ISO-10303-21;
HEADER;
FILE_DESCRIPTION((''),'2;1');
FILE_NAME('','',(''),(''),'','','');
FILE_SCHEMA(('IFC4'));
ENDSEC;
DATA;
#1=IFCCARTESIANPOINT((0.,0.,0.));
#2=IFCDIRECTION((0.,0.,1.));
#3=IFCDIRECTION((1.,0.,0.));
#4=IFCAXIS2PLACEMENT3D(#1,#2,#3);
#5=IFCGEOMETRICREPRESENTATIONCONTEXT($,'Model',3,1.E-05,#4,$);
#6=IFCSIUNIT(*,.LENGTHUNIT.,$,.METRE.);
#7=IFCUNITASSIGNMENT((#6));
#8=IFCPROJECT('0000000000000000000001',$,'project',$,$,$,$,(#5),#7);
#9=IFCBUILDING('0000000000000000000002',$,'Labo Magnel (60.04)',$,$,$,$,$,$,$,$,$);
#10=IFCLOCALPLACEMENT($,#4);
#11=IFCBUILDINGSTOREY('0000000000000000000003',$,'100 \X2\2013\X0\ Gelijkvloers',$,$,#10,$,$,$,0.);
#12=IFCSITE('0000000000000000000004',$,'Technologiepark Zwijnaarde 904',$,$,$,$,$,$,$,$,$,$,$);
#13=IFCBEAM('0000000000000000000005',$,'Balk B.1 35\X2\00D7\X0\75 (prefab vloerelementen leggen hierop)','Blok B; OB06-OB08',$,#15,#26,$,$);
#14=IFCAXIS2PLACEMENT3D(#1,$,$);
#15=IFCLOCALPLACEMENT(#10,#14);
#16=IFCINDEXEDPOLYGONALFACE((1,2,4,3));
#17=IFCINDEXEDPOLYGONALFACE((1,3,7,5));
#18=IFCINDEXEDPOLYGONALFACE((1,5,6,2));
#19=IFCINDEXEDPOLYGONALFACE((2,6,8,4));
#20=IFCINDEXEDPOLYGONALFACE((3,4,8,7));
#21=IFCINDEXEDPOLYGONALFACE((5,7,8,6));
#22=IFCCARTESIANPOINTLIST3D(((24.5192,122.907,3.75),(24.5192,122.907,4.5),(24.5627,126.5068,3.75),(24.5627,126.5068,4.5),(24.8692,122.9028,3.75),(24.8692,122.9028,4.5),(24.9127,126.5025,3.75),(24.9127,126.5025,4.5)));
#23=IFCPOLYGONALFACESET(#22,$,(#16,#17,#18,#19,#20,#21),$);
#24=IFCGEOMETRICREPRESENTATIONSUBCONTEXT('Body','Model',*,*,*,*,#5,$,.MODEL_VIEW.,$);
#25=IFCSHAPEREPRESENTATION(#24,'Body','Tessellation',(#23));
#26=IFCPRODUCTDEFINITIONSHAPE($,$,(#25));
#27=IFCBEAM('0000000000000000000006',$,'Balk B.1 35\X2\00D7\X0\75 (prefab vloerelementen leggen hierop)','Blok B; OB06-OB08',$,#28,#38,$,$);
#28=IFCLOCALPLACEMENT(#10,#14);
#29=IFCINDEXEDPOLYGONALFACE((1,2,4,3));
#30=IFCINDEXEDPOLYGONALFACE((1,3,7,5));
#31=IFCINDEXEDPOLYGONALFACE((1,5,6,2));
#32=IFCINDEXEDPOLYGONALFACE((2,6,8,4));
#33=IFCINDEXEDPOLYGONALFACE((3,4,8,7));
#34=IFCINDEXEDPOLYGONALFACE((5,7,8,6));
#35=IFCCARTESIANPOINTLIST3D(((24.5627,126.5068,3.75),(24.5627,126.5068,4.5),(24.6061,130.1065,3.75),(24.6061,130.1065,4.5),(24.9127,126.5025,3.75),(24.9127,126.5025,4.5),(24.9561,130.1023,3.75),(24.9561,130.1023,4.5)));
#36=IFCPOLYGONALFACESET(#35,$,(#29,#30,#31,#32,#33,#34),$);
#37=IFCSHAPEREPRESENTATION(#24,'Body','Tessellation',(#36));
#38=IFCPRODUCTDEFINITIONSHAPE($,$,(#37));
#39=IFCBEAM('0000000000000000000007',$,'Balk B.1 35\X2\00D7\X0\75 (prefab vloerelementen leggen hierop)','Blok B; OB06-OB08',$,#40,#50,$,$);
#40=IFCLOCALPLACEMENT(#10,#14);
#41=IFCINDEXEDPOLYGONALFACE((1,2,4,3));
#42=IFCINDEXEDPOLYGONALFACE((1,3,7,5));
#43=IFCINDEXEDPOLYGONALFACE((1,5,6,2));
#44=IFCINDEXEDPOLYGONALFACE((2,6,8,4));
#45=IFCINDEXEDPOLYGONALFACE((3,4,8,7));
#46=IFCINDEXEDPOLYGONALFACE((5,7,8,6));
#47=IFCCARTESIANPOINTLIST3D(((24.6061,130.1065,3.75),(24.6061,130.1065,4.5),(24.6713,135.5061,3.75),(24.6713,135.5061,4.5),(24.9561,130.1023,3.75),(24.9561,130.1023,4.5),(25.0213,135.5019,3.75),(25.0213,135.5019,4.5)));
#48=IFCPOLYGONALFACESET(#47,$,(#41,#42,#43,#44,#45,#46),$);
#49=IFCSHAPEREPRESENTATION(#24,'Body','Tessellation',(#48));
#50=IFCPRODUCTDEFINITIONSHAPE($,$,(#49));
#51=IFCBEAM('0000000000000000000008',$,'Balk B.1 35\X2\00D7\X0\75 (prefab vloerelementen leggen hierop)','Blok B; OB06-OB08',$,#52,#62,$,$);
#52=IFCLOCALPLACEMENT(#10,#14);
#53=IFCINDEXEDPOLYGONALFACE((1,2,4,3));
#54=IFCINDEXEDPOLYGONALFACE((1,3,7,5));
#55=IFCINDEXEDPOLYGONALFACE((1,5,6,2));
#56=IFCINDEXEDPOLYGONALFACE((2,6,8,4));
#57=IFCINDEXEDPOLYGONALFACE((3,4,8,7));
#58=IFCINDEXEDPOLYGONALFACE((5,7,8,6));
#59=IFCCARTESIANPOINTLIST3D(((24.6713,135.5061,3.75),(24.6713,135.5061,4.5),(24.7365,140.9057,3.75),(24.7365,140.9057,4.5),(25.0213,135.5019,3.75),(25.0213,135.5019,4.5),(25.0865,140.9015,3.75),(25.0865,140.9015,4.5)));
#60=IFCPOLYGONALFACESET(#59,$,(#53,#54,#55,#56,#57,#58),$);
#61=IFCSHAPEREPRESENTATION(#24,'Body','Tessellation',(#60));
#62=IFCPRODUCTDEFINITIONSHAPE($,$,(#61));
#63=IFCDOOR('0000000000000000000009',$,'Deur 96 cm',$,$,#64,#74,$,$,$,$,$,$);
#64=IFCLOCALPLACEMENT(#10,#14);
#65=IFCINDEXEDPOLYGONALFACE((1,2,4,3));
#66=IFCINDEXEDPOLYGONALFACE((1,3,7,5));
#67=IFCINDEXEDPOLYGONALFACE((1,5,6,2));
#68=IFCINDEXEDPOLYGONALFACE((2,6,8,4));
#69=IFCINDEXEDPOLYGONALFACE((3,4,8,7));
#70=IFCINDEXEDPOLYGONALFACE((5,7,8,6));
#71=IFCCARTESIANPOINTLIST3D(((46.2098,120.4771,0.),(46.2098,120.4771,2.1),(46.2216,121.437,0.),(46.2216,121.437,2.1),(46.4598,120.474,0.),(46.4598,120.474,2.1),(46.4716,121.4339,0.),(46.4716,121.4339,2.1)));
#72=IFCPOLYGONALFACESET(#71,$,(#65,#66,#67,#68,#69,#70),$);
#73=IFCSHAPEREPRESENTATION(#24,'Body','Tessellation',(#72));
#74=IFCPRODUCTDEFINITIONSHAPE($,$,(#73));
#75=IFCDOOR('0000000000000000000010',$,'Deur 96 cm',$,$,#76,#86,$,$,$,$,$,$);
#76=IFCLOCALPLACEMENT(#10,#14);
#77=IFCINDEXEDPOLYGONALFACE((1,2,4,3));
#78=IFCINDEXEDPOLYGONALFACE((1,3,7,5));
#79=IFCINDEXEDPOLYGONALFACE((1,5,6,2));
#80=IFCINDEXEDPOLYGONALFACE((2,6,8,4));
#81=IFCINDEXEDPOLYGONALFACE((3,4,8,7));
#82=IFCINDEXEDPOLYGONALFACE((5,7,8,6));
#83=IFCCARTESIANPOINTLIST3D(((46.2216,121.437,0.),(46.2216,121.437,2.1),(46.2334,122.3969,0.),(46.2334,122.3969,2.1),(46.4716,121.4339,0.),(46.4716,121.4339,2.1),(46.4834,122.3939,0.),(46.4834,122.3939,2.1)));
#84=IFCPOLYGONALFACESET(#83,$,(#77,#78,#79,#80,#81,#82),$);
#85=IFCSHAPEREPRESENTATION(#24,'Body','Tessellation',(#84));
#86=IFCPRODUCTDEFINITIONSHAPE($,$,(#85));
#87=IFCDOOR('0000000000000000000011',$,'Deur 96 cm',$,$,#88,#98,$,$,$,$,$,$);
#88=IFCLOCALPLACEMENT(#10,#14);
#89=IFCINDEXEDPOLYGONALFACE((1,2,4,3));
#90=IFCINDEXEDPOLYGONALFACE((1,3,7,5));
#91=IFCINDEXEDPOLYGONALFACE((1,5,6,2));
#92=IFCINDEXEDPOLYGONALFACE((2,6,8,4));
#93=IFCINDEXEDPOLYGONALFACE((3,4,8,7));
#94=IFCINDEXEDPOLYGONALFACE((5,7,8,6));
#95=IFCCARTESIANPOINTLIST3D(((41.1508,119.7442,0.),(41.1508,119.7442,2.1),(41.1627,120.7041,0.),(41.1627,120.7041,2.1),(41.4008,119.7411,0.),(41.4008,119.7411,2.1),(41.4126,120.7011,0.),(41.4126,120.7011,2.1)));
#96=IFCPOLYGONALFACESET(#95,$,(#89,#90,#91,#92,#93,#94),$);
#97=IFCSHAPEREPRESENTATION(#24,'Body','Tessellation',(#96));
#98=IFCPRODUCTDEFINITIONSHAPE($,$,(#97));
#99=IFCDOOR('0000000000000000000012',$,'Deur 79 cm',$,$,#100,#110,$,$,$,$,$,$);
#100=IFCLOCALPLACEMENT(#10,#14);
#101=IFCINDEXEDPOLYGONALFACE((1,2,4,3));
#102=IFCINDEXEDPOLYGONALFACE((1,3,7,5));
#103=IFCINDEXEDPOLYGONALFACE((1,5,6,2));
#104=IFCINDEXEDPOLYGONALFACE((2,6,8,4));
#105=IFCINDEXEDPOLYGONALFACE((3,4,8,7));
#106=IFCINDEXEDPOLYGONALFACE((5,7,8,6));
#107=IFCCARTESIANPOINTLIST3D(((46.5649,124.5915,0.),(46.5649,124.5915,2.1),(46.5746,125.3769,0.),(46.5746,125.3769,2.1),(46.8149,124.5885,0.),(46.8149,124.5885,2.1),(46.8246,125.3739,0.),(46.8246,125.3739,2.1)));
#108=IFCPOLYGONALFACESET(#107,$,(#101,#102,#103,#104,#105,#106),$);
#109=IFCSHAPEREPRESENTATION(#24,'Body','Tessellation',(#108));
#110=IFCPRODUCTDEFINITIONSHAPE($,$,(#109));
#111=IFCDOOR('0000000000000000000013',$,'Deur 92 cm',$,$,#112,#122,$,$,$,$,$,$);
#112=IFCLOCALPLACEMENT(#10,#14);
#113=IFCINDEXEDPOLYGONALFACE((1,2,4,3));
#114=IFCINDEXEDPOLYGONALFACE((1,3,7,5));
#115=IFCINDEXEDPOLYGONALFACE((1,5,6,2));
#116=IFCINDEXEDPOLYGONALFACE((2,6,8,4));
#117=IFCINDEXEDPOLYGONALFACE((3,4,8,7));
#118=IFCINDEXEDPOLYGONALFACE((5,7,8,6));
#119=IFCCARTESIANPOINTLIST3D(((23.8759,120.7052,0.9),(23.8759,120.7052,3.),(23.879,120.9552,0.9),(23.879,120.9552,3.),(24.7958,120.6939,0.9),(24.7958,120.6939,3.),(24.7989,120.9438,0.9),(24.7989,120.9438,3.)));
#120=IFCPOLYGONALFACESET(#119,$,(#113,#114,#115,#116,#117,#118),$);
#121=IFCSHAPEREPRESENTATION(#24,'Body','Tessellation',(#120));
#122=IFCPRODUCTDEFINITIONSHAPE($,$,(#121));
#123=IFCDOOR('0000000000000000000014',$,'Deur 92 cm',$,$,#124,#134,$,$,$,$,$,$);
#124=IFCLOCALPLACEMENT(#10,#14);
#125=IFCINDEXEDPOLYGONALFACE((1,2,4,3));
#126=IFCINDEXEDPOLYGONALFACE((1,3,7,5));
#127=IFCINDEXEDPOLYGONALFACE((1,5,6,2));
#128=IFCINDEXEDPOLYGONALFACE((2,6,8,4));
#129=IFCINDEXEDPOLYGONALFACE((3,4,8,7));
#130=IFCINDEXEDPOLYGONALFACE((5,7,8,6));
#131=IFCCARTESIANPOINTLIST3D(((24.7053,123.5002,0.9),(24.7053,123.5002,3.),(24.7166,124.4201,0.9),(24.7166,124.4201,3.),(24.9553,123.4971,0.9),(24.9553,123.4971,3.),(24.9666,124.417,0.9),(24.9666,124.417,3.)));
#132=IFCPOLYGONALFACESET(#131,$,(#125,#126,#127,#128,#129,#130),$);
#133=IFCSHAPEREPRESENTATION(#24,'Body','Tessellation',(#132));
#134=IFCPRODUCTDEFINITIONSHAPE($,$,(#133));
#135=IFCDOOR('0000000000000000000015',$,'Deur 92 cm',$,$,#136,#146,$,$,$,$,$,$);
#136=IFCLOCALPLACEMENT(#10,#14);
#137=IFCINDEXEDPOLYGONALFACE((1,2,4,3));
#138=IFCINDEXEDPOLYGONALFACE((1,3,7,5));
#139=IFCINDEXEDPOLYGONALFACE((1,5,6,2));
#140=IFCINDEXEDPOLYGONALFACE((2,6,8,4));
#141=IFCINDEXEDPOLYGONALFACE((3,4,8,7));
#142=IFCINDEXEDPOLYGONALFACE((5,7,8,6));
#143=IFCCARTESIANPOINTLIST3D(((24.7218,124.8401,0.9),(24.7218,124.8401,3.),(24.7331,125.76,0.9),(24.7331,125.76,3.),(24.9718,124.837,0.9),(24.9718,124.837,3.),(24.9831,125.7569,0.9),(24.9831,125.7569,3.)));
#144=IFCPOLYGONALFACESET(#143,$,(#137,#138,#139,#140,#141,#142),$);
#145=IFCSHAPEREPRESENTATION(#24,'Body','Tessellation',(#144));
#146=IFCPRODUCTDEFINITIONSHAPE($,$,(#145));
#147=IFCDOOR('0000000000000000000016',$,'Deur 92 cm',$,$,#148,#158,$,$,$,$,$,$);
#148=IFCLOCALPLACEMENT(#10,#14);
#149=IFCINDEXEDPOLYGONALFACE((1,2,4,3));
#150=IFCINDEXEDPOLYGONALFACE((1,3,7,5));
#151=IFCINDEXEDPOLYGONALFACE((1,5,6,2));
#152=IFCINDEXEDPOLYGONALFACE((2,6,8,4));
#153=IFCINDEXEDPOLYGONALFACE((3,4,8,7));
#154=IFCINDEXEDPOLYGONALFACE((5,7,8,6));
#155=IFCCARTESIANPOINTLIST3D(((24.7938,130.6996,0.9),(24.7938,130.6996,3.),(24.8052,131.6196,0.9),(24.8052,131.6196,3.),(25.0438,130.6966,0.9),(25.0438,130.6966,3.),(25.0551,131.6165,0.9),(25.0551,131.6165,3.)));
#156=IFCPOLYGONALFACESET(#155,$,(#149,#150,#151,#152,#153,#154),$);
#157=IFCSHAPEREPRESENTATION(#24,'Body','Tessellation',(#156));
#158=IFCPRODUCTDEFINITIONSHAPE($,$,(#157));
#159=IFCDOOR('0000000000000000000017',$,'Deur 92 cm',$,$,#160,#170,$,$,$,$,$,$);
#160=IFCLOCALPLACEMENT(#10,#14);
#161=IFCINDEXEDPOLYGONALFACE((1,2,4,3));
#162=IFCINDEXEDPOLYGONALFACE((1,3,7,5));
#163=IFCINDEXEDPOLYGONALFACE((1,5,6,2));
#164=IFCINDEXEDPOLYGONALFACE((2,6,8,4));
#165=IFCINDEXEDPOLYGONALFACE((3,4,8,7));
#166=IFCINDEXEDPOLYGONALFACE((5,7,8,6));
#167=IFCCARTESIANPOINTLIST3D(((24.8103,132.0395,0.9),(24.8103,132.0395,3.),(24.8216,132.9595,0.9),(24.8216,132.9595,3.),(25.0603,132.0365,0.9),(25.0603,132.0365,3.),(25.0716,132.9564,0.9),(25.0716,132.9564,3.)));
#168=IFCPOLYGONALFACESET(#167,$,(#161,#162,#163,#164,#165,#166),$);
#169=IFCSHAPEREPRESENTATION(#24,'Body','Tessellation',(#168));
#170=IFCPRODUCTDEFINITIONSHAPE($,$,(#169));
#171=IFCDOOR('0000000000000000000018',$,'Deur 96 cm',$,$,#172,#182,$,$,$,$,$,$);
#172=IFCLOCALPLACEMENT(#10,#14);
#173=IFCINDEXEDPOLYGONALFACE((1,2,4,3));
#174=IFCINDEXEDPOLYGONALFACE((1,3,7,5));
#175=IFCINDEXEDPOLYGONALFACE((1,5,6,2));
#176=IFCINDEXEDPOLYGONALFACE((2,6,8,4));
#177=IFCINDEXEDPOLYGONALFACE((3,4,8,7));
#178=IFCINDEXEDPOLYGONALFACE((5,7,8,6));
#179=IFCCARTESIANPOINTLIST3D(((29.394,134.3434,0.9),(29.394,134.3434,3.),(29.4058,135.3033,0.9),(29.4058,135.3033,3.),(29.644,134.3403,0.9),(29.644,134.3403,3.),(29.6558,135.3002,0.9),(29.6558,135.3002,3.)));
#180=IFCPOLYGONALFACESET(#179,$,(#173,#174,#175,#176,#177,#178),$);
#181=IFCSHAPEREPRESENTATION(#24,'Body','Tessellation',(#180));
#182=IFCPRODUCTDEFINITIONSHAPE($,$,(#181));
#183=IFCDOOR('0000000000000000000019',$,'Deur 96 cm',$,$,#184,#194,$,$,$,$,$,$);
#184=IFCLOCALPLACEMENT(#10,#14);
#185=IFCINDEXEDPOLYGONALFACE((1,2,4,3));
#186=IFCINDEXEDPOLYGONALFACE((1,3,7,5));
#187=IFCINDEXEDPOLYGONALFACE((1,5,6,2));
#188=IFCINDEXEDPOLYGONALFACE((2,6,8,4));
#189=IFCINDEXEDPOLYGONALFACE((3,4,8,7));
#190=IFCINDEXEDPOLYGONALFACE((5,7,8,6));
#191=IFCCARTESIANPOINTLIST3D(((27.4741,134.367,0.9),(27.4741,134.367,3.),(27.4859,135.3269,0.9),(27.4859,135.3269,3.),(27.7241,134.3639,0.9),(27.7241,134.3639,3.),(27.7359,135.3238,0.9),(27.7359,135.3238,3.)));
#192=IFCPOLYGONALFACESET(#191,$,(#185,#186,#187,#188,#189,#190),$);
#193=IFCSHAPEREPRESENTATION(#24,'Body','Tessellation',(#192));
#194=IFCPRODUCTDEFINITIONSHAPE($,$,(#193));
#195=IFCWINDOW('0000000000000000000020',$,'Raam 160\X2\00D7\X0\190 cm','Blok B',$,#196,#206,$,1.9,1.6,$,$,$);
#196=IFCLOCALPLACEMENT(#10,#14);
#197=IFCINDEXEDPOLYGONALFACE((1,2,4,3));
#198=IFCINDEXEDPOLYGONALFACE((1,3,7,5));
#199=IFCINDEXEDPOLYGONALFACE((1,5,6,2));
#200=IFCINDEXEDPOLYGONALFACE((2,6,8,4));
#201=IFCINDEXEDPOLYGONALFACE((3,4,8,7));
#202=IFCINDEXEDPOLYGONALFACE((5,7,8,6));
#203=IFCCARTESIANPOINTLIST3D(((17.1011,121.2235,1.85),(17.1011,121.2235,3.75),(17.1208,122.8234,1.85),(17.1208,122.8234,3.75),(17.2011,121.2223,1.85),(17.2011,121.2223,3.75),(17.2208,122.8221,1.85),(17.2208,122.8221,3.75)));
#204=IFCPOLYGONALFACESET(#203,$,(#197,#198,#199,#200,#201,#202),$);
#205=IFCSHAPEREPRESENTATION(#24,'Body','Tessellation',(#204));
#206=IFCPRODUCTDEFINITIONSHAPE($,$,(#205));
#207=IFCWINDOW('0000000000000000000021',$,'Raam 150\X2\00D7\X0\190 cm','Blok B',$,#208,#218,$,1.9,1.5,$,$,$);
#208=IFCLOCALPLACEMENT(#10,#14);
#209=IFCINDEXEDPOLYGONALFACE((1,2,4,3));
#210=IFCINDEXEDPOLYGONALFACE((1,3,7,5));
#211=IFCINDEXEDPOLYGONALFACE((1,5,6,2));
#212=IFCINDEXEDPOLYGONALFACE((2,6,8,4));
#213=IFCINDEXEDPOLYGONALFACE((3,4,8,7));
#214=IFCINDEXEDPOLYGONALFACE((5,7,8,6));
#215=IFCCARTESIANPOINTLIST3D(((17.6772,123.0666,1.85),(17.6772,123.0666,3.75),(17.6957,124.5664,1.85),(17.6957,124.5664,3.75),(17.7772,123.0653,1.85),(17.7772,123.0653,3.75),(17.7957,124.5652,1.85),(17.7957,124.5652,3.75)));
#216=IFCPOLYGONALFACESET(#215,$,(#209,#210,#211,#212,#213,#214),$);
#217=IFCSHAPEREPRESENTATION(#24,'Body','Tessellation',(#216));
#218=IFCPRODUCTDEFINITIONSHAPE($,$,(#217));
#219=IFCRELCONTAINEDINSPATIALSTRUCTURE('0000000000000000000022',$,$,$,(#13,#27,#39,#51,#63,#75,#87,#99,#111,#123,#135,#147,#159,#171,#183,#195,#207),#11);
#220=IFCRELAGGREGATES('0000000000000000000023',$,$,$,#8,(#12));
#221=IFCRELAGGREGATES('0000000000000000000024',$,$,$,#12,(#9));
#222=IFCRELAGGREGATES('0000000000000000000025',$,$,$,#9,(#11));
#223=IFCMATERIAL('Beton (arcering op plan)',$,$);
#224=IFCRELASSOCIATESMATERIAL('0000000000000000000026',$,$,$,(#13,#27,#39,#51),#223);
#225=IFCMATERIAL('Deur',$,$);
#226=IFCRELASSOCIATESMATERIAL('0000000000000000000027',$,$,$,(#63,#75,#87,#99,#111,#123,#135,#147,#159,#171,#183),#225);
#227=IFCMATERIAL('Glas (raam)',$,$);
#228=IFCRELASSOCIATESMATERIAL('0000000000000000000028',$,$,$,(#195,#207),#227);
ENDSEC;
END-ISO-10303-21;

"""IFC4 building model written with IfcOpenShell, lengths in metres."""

from ifc_helpers import new_model, si_unit, frame, origin, origin_with_axes, place, context, subcontext, project, spatial, polyline, outline, extrude, material, element, save


model = new_model("IFC4")

# Units and contexts
model_context = context("Model", 3, precision=1e-05, world=origin_with_axes())
body_context = subcontext(model_context, "Body", "Model", "MODEL_VIEW")
ifc_project = project(units=[si_unit("LENGTHUNIT", "METRE")], contexts=[model_context])

# Site, building, storey
site = spatial("IfcSite", under=ifc_project, Name="Technologiepark Zwijnaarde 904")
building = spatial("IfcBuilding", under=site, Name="Labo Magnel (60.04)")
storey_placement = place(None, origin_with_axes())
storey = spatial("IfcBuildingStorey", under=building, at=storey_placement, Name="100 – Gelijkvloers", Elevation=0.0)

# Beams
ifc_material_1 = material(Name="Beton (arcering op plan)")
beam_1_placement = place(storey_placement, frame((24.6942, 122.9049, 3.75), z_axis=(0.0, 0.0, 1.0), x_axis=(0.01207, 0.999927, 0.0)))
element("IfcBeam", 1, at=beam_1_placement, inside=storey, material=ifc_material_1, Name="Balk B.1 35×75 (prefab vloerelementen leggen hierop)", Description="Blok B; OB06-OB08", context=body_context, shape_type="SweptSolid", body=[
    extrude(outline(polyline([(0.0, -0.175), (3.6, -0.175), (3.6, 0.175), (0.0, 0.175), (0.0, -0.175)])), origin(), (0.0, 0.0, 1.0), 0.75),
])
beam_2_placement = place(storey_placement, frame((24.7377, 126.5046, 3.75), z_axis=(0.0, 0.0, 1.0), x_axis=(0.01207, 0.999927, 0.0)))
element("IfcBeam", 2, at=beam_2_placement, inside=storey, material=ifc_material_1, Name="Balk B.1 35×75 (prefab vloerelementen leggen hierop)", Description="Blok B; OB06-OB08", context=body_context, shape_type="SweptSolid", body=[
    extrude(outline(polyline([(0.0, -0.175), (3.6, -0.175), (3.6, 0.175), (0.0, 0.175), (0.0, -0.175)])), origin(), (0.0, 0.0, 1.0), 0.75),
])
beam_3_placement = place(storey_placement, frame((24.7811, 130.1044, 3.75), z_axis=(0.0, 0.0, 1.0), x_axis=(0.01207, 0.999927, 0.0)))
element("IfcBeam", 3, at=beam_3_placement, inside=storey, material=ifc_material_1, Name="Balk B.1 35×75 (prefab vloerelementen leggen hierop)", Description="Blok B; OB06-OB08", context=body_context, shape_type="SweptSolid", body=[
    extrude(outline(polyline([(0.0, -0.175), (5.4, -0.175), (5.4, 0.175), (0.0, 0.175), (0.0, -0.175)])), origin(), (0.0, 0.0, 1.0), 0.75),
])
beam_4_placement = place(storey_placement, frame((24.8463, 135.504, 3.75), z_axis=(0.0, 0.0, 1.0), x_axis=(0.01207, 0.999927, 0.0)))
element("IfcBeam", 4, at=beam_4_placement, inside=storey, material=ifc_material_1, Name="Balk B.1 35×75 (prefab vloerelementen leggen hierop)", Description="Blok B; OB06-OB08", context=body_context, shape_type="SweptSolid", body=[
    extrude(outline(polyline([(0.0, -0.175), (5.4, -0.175), (5.4, 0.175), (0.0, 0.175), (0.0, -0.175)])), origin(), (0.0, 0.0, 1.0), 0.75),
])

# Doors
ifc_material_2 = material(Name="Deur")
for number, where, z_axis, x_axis, name in (
    (5, (46.3348, 120.4755, 0.0), (0.0, 0.0, 1.0), (0.012293, 0.999924, 0.0), "Deur 96 cm"),
    (6, (46.3584, 122.3954, 0.0), (0.0, 0.0, 1.0), (-0.012293, -0.999924, 0.0), "Deur 96 cm"),
):
    element("IfcDoor", number, at=place(storey_placement, frame(where, z_axis=z_axis, x_axis=x_axis)), inside=storey, material=ifc_material_2, Name=name, context=body_context, shape_type="SweptSolid", body=[
        extrude(outline(polyline([(0.0, -0.125), (0.96, -0.125), (0.96, 0.125), (0.0, 0.125), (0.0, -0.125)])), origin(), (0.0, 0.0, 1.0), 2.1),
    ])
door_1_placement = place(storey_placement, frame((41.2758, 119.7427, 0.0), z_axis=(0.0, 0.0, 1.0), x_axis=(0.012293, 0.999924, 0.0)))
element("IfcDoor", 7, at=door_1_placement, inside=storey, material=ifc_material_2, Name="Deur 96 cm", context=body_context, shape_type="SweptSolid", body=[
    extrude(outline(polyline([(0.0, -0.125), (0.96, -0.125), (0.96, 0.125), (0.0, 0.125), (0.0, -0.125)])), origin(), (0.0, 0.0, 1.0), 2.1),
])
door_2_placement = place(storey_placement, frame((46.6899, 124.59, 0.0), z_axis=(0.0, 0.0, 1.0), x_axis=(0.012293, 0.999924, 0.0)))
element("IfcDoor", 8, at=door_2_placement, inside=storey, material=ifc_material_2, Name="Deur 79 cm", context=body_context, shape_type="SweptSolid", body=[
    extrude(outline(polyline([(0.0, -0.125), (0.7855, -0.125), (0.7855, 0.125), (0.0, 0.125), (0.0, -0.125)])), origin(), (0.0, 0.0, 1.0), 2.1),
])
for number, where, z_axis, x_axis, name in (
    (9, (24.7974, 120.8189, 0.9), (0.0, 0.0, 1.0), (-0.999924, 0.012293, 0.0), "Deur 92 cm"),
    (10, (24.8416, 124.4186, 0.9), (0.0, 0.0, 1.0), (-0.012293, -0.999924, 0.0), "Deur 92 cm"),
    (11, (24.8468, 124.8386, 0.9), (0.0, 0.0, 1.0), (0.012293, 0.999924, 0.0), "Deur 92 cm"),
    (12, (24.9301, 131.618, 0.9), (0.0, 0.0, 1.0), (-0.012293, -0.999924, 0.0), "Deur 92 cm"),
    (13, (24.9353, 132.038, 0.9), (0.0, 0.0, 1.0), (0.012293, 0.999924, 0.0), "Deur 92 cm"),
):
    element("IfcDoor", number, at=place(storey_placement, frame(where, z_axis=z_axis, x_axis=x_axis)), inside=storey, material=ifc_material_2, Name=name, context=body_context, shape_type="SweptSolid", body=[
        extrude(outline(polyline([(0.0, -0.125), (0.92, -0.125), (0.92, 0.125), (0.0, 0.125), (0.0, -0.125)])), origin(), (0.0, 0.0, 1.0), 2.1),
    ])
for number, where, z_axis, x_axis, name in (
    (14, (29.5308, 135.3018, 0.9), (0.0, 0.0, 1.0), (-0.012293, -0.999924, 0.0), "Deur 96 cm"),
    (15, (27.6109, 135.3254, 0.9), (0.0, 0.0, 1.0), (-0.012293, -0.999924, 0.0), "Deur 96 cm"),
):
    element("IfcDoor", number, at=place(storey_placement, frame(where, z_axis=z_axis, x_axis=x_axis)), inside=storey, material=ifc_material_2, Name=name, context=body_context, shape_type="SweptSolid", body=[
        extrude(outline(polyline([(0.0, -0.125), (0.96, -0.125), (0.96, 0.125), (0.0, 0.125), (0.0, -0.125)])), origin(), (0.0, 0.0, 1.0), 2.1),
    ])

# Windows
ifc_material_3 = material(Name="Glas (raam)")
window_1_placement = place(storey_placement, frame((17.1511, 121.2229, 1.85), z_axis=(0.0, 0.0, 1.0), x_axis=(0.012293, 0.999924, 0.0)))
element("IfcWindow", 16, at=window_1_placement, inside=storey, material=ifc_material_3, Name="Raam 160×190 cm", Description="Blok B", OverallHeight=1.9, OverallWidth=1.6, context=body_context, shape_type="SweptSolid", body=[
    extrude(outline(polyline([(0.0, -0.05), (1.6, -0.05), (1.6, 0.05), (0.0, 0.05), (0.0, -0.05)])), origin(), (0.0, 0.0, 1.0), 1.9),
])
window_2_placement = place(storey_placement, frame((17.7457, 124.5658, 1.85), z_axis=(0.0, 0.0, 1.0), x_axis=(-0.012293, -0.999924, 0.0)))
element("IfcWindow", 17, at=window_2_placement, inside=storey, material=ifc_material_3, Name="Raam 150×190 cm", Description="Blok B", OverallHeight=1.9, OverallWidth=1.5, context=body_context, shape_type="SweptSolid", body=[
    extrude(outline(polyline([(0.0, -0.05), (1.5, -0.05), (1.5, 0.05), (0.0, 0.05), (0.0, -0.05)])), origin(), (0.0, 0.0, 1.0), 1.9),
])

save(model, "model.ifc")
